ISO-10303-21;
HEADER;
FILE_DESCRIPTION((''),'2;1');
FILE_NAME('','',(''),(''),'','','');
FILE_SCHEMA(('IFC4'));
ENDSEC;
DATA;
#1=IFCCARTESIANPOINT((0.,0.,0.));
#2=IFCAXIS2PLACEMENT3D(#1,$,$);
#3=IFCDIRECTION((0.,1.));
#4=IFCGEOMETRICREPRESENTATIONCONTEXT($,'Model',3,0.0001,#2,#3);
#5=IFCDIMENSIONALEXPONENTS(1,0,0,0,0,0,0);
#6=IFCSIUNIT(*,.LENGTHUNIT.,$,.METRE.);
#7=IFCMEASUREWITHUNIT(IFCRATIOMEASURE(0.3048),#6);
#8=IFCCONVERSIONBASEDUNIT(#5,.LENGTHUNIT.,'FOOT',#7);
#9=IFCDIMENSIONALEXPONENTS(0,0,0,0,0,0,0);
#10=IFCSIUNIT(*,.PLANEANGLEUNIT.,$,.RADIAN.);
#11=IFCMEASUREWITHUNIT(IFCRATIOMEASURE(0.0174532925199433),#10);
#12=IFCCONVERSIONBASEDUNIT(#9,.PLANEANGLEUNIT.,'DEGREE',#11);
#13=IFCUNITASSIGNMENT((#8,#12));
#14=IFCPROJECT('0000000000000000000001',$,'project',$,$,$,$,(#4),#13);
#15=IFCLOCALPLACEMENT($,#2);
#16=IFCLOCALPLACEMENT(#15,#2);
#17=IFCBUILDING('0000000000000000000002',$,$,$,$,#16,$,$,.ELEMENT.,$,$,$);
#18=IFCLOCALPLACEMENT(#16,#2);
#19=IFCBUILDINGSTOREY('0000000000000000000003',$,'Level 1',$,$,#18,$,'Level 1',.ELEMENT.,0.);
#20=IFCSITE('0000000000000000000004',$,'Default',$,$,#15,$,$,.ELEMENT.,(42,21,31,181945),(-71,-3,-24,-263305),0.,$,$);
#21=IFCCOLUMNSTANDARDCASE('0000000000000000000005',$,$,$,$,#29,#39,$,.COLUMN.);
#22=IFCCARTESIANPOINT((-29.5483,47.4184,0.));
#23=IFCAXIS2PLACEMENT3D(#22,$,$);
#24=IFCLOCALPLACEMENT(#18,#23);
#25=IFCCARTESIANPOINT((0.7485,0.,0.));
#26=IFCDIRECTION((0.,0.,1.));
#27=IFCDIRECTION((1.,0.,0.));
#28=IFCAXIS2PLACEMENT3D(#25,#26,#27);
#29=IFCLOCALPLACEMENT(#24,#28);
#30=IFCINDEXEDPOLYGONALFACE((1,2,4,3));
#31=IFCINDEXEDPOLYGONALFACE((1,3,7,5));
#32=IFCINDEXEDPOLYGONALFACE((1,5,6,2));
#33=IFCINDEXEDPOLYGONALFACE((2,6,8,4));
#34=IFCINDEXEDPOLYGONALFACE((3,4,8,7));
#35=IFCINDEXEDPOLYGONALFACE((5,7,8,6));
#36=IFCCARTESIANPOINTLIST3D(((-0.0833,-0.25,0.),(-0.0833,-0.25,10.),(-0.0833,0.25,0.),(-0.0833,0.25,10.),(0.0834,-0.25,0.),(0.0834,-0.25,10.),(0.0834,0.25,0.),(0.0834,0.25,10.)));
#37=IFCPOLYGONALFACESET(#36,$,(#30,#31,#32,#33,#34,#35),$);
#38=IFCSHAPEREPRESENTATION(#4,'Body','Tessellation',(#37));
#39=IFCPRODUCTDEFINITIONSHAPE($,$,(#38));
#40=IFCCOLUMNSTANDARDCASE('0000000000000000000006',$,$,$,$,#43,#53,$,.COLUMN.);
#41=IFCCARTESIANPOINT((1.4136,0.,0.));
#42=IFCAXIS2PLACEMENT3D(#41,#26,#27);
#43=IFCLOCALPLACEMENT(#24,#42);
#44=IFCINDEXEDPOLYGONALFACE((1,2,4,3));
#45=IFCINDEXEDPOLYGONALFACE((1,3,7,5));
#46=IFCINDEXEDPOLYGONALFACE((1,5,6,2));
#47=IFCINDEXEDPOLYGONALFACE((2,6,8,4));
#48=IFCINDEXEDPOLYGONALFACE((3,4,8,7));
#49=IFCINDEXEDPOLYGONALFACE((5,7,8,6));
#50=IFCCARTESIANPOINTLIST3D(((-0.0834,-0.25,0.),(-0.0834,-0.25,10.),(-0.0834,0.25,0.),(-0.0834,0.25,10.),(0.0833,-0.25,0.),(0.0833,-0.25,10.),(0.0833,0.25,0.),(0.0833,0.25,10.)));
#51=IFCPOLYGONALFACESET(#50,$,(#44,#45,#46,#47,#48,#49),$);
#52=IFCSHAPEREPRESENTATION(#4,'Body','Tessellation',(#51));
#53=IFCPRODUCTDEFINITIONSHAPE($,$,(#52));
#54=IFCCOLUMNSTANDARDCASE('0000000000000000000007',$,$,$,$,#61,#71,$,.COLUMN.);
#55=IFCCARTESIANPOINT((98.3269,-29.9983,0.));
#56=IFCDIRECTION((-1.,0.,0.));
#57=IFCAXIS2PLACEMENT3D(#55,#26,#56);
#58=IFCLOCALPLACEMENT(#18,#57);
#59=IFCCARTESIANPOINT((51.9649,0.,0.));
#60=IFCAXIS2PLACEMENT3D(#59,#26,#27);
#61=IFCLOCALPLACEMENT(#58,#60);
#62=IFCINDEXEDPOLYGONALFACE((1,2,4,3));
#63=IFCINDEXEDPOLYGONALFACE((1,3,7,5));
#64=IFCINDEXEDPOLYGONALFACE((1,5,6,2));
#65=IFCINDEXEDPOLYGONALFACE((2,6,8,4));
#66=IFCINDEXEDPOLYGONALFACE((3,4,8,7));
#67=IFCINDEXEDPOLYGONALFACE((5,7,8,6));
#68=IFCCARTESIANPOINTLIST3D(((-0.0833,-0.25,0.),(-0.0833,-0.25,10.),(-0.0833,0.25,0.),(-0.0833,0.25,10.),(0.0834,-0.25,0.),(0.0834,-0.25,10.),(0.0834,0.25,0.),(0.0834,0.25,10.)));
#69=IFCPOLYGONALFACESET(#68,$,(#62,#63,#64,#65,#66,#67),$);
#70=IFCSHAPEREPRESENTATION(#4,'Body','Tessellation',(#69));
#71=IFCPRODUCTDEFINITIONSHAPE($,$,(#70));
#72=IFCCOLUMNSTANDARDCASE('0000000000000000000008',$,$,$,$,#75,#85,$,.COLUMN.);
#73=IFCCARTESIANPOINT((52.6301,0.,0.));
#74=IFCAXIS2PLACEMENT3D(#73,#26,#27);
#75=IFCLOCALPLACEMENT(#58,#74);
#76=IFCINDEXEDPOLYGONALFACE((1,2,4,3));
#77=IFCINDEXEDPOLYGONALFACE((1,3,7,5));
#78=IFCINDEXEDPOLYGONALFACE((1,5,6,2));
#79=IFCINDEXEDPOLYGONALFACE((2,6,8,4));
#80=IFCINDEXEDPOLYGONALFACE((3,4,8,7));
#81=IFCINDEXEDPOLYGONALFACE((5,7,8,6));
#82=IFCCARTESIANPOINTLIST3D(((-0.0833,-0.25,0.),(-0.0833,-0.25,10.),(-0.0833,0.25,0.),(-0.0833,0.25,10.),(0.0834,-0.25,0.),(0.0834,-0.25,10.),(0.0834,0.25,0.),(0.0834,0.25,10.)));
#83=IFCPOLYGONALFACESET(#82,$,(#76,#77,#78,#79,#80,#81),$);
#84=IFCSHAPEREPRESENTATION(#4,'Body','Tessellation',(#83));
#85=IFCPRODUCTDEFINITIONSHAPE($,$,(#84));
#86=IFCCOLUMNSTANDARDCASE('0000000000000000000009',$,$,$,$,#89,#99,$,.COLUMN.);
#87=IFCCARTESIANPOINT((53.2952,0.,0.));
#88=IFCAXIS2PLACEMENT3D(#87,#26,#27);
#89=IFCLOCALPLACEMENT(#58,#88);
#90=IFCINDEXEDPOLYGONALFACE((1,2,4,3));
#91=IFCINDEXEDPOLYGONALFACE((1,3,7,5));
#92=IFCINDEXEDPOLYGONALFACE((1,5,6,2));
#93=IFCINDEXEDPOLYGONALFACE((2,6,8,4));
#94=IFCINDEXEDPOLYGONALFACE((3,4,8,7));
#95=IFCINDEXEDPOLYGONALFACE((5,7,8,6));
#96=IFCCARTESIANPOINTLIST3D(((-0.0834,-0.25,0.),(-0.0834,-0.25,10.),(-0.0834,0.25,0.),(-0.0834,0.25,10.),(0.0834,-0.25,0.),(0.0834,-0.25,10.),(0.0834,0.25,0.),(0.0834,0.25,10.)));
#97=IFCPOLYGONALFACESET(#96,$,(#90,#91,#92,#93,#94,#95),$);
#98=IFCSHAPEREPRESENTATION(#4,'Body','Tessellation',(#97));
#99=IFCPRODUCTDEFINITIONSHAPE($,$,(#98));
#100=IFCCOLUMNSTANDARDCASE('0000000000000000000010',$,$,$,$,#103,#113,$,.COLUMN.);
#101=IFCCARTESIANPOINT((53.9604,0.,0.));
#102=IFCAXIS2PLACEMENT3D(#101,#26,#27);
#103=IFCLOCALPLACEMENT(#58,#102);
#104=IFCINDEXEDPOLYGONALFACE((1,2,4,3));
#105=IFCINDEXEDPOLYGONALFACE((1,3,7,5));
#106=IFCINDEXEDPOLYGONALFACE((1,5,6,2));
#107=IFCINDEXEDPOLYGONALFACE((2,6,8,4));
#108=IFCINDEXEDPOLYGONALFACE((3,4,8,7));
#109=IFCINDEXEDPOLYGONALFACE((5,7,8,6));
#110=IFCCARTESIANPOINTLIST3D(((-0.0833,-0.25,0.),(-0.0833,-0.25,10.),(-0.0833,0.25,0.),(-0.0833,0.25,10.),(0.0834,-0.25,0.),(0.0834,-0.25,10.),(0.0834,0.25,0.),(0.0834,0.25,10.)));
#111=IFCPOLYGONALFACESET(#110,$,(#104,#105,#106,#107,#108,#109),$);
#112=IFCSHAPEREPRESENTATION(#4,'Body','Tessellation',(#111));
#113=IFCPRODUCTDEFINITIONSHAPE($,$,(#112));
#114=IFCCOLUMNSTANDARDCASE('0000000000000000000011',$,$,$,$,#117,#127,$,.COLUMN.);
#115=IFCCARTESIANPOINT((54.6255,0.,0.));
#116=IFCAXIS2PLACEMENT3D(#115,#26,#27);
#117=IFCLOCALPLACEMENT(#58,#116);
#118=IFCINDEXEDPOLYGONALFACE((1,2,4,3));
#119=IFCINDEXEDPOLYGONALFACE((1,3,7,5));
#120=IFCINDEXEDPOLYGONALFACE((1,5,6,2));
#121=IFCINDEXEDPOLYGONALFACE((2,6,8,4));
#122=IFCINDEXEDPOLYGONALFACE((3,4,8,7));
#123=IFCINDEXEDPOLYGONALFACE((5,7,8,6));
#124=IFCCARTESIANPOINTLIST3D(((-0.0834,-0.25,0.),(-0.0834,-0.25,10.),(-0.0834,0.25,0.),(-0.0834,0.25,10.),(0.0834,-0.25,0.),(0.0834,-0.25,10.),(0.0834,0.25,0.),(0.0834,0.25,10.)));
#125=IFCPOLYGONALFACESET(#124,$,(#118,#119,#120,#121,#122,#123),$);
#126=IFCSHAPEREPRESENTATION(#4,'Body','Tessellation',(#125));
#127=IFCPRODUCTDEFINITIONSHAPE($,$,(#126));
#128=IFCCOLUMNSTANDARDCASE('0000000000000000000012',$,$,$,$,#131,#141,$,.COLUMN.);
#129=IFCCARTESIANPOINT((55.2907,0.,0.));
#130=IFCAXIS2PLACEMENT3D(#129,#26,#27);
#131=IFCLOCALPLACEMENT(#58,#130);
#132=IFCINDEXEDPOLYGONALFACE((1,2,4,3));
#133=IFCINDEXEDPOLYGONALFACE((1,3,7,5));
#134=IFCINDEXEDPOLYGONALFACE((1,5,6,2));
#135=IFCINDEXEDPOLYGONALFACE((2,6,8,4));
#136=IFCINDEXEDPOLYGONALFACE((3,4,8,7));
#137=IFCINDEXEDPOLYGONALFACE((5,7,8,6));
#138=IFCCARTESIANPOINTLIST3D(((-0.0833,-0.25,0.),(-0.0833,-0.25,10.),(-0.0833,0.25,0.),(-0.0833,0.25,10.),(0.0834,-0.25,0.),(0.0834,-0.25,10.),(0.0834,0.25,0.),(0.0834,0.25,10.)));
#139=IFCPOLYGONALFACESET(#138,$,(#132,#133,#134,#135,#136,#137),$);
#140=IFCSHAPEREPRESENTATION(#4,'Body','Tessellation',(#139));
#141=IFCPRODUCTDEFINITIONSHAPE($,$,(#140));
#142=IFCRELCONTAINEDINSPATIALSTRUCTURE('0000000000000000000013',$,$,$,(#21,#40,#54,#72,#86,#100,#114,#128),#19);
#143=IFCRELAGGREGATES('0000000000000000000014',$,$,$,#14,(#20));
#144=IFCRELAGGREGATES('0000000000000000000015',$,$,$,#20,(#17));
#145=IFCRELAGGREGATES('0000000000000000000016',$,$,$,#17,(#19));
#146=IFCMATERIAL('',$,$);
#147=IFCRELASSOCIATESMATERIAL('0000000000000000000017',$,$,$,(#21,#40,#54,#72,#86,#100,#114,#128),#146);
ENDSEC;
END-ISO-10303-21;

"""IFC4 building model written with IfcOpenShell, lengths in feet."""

from ifc_helpers import new_model, entity, si_unit, converted_unit, direction, frame, origin, place, context, project, spatial, rectangle, extrude, material, element, save


model = new_model("IFC4")

# Units and contexts
model_context = context("Model", 3, precision=0.0001, world=origin(), true_north=direction((0.0, 1.0)))
ifc_project = project(units=[converted_unit("LENGTHUNIT", "FOOT", entity("IfcRatioMeasure", 0.3048), si_unit("LENGTHUNIT", "METRE"), dimensions=[1, 0, 0, 0, 0, 0, 0]), converted_unit("PLANEANGLEUNIT", "DEGREE", entity("IfcRatioMeasure", 0.0174532925199433), si_unit("PLANEANGLEUNIT", "RADIAN"), dimensions=[0, 0, 0, 0, 0, 0, 0])], contexts=[model_context])

# Site, building, storey
site_placement = place(None, origin())
site = spatial("IfcSite", under=ifc_project, at=site_placement, Name="Default", CompositionType="ELEMENT", RefLatitude=(42, 21, 31, 181945), RefLongitude=(-71, -3, -24, -263305), RefElevation=0.0)
building_placement = place(site_placement, origin())
building = spatial("IfcBuilding", under=site, at=building_placement, CompositionType="ELEMENT")
storey_placement = place(building_placement, origin())
storey = spatial("IfcBuildingStorey", under=building, at=storey_placement, Name="Level 1", LongName="Level 1", CompositionType="ELEMENT", Elevation=0.0)

# Columns
ifc_material_1 = material(Name="")
wall_1_placement = place(storey_placement, frame((-29.5483, 47.4184, 0.0)))
for number, where, z_axis, x_axis in (
    (1, (0.7485, 0.0, 0.0), (0.0, 0.0, 1.0), (1.0, 0.0, 0.0)),
    (2, (1.4136, 0.0, 0.0), (0.0, 0.0, 1.0), (1.0, 0.0, 0.0)),
):
    element("IfcColumnStandardCase", number, at=place(wall_1_placement, frame(where, z_axis=z_axis, x_axis=x_axis)), inside=storey, material=ifc_material_1, PredefinedType="COLUMN", context=model_context, shape_type="SweptSolid", body=[
        extrude(rectangle(XDim=0.1667, YDim=0.5), origin(), (0.0, 0.0, 1.0), 10.0),
    ])
placement = place(storey_placement, frame((98.3269, -29.9983, 0.0), z_axis=(0.0, 0.0, 1.0), x_axis=(-1.0, 0.0, 0.0)))
for number, where, z_axis, x_axis in (
    (3, (51.9649, 0.0, 0.0), (0.0, 0.0, 1.0), (1.0, 0.0, 0.0)),
    (4, (52.6301, 0.0, 0.0), (0.0, 0.0, 1.0), (1.0, 0.0, 0.0)),
    (5, (53.2952, 0.0, 0.0), (0.0, 0.0, 1.0), (1.0, 0.0, 0.0)),
    (6, (53.9604, 0.0, 0.0), (0.0, 0.0, 1.0), (1.0, 0.0, 0.0)),
    (7, (54.6255, 0.0, 0.0), (0.0, 0.0, 1.0), (1.0, 0.0, 0.0)),
    (8, (55.2907, 0.0, 0.0), (0.0, 0.0, 1.0), (1.0, 0.0, 0.0)),
):
    element("IfcColumnStandardCase", number, at=place(placement, frame(where, z_axis=z_axis, x_axis=x_axis)), inside=storey, material=ifc_material_1, PredefinedType="COLUMN", context=model_context, shape_type="SweptSolid", body=[
        extrude(rectangle(XDim=0.1667, YDim=0.5), origin(), (0.0, 0.0, 1.0), 10.0),
    ])

save(model, "model.ifc")
